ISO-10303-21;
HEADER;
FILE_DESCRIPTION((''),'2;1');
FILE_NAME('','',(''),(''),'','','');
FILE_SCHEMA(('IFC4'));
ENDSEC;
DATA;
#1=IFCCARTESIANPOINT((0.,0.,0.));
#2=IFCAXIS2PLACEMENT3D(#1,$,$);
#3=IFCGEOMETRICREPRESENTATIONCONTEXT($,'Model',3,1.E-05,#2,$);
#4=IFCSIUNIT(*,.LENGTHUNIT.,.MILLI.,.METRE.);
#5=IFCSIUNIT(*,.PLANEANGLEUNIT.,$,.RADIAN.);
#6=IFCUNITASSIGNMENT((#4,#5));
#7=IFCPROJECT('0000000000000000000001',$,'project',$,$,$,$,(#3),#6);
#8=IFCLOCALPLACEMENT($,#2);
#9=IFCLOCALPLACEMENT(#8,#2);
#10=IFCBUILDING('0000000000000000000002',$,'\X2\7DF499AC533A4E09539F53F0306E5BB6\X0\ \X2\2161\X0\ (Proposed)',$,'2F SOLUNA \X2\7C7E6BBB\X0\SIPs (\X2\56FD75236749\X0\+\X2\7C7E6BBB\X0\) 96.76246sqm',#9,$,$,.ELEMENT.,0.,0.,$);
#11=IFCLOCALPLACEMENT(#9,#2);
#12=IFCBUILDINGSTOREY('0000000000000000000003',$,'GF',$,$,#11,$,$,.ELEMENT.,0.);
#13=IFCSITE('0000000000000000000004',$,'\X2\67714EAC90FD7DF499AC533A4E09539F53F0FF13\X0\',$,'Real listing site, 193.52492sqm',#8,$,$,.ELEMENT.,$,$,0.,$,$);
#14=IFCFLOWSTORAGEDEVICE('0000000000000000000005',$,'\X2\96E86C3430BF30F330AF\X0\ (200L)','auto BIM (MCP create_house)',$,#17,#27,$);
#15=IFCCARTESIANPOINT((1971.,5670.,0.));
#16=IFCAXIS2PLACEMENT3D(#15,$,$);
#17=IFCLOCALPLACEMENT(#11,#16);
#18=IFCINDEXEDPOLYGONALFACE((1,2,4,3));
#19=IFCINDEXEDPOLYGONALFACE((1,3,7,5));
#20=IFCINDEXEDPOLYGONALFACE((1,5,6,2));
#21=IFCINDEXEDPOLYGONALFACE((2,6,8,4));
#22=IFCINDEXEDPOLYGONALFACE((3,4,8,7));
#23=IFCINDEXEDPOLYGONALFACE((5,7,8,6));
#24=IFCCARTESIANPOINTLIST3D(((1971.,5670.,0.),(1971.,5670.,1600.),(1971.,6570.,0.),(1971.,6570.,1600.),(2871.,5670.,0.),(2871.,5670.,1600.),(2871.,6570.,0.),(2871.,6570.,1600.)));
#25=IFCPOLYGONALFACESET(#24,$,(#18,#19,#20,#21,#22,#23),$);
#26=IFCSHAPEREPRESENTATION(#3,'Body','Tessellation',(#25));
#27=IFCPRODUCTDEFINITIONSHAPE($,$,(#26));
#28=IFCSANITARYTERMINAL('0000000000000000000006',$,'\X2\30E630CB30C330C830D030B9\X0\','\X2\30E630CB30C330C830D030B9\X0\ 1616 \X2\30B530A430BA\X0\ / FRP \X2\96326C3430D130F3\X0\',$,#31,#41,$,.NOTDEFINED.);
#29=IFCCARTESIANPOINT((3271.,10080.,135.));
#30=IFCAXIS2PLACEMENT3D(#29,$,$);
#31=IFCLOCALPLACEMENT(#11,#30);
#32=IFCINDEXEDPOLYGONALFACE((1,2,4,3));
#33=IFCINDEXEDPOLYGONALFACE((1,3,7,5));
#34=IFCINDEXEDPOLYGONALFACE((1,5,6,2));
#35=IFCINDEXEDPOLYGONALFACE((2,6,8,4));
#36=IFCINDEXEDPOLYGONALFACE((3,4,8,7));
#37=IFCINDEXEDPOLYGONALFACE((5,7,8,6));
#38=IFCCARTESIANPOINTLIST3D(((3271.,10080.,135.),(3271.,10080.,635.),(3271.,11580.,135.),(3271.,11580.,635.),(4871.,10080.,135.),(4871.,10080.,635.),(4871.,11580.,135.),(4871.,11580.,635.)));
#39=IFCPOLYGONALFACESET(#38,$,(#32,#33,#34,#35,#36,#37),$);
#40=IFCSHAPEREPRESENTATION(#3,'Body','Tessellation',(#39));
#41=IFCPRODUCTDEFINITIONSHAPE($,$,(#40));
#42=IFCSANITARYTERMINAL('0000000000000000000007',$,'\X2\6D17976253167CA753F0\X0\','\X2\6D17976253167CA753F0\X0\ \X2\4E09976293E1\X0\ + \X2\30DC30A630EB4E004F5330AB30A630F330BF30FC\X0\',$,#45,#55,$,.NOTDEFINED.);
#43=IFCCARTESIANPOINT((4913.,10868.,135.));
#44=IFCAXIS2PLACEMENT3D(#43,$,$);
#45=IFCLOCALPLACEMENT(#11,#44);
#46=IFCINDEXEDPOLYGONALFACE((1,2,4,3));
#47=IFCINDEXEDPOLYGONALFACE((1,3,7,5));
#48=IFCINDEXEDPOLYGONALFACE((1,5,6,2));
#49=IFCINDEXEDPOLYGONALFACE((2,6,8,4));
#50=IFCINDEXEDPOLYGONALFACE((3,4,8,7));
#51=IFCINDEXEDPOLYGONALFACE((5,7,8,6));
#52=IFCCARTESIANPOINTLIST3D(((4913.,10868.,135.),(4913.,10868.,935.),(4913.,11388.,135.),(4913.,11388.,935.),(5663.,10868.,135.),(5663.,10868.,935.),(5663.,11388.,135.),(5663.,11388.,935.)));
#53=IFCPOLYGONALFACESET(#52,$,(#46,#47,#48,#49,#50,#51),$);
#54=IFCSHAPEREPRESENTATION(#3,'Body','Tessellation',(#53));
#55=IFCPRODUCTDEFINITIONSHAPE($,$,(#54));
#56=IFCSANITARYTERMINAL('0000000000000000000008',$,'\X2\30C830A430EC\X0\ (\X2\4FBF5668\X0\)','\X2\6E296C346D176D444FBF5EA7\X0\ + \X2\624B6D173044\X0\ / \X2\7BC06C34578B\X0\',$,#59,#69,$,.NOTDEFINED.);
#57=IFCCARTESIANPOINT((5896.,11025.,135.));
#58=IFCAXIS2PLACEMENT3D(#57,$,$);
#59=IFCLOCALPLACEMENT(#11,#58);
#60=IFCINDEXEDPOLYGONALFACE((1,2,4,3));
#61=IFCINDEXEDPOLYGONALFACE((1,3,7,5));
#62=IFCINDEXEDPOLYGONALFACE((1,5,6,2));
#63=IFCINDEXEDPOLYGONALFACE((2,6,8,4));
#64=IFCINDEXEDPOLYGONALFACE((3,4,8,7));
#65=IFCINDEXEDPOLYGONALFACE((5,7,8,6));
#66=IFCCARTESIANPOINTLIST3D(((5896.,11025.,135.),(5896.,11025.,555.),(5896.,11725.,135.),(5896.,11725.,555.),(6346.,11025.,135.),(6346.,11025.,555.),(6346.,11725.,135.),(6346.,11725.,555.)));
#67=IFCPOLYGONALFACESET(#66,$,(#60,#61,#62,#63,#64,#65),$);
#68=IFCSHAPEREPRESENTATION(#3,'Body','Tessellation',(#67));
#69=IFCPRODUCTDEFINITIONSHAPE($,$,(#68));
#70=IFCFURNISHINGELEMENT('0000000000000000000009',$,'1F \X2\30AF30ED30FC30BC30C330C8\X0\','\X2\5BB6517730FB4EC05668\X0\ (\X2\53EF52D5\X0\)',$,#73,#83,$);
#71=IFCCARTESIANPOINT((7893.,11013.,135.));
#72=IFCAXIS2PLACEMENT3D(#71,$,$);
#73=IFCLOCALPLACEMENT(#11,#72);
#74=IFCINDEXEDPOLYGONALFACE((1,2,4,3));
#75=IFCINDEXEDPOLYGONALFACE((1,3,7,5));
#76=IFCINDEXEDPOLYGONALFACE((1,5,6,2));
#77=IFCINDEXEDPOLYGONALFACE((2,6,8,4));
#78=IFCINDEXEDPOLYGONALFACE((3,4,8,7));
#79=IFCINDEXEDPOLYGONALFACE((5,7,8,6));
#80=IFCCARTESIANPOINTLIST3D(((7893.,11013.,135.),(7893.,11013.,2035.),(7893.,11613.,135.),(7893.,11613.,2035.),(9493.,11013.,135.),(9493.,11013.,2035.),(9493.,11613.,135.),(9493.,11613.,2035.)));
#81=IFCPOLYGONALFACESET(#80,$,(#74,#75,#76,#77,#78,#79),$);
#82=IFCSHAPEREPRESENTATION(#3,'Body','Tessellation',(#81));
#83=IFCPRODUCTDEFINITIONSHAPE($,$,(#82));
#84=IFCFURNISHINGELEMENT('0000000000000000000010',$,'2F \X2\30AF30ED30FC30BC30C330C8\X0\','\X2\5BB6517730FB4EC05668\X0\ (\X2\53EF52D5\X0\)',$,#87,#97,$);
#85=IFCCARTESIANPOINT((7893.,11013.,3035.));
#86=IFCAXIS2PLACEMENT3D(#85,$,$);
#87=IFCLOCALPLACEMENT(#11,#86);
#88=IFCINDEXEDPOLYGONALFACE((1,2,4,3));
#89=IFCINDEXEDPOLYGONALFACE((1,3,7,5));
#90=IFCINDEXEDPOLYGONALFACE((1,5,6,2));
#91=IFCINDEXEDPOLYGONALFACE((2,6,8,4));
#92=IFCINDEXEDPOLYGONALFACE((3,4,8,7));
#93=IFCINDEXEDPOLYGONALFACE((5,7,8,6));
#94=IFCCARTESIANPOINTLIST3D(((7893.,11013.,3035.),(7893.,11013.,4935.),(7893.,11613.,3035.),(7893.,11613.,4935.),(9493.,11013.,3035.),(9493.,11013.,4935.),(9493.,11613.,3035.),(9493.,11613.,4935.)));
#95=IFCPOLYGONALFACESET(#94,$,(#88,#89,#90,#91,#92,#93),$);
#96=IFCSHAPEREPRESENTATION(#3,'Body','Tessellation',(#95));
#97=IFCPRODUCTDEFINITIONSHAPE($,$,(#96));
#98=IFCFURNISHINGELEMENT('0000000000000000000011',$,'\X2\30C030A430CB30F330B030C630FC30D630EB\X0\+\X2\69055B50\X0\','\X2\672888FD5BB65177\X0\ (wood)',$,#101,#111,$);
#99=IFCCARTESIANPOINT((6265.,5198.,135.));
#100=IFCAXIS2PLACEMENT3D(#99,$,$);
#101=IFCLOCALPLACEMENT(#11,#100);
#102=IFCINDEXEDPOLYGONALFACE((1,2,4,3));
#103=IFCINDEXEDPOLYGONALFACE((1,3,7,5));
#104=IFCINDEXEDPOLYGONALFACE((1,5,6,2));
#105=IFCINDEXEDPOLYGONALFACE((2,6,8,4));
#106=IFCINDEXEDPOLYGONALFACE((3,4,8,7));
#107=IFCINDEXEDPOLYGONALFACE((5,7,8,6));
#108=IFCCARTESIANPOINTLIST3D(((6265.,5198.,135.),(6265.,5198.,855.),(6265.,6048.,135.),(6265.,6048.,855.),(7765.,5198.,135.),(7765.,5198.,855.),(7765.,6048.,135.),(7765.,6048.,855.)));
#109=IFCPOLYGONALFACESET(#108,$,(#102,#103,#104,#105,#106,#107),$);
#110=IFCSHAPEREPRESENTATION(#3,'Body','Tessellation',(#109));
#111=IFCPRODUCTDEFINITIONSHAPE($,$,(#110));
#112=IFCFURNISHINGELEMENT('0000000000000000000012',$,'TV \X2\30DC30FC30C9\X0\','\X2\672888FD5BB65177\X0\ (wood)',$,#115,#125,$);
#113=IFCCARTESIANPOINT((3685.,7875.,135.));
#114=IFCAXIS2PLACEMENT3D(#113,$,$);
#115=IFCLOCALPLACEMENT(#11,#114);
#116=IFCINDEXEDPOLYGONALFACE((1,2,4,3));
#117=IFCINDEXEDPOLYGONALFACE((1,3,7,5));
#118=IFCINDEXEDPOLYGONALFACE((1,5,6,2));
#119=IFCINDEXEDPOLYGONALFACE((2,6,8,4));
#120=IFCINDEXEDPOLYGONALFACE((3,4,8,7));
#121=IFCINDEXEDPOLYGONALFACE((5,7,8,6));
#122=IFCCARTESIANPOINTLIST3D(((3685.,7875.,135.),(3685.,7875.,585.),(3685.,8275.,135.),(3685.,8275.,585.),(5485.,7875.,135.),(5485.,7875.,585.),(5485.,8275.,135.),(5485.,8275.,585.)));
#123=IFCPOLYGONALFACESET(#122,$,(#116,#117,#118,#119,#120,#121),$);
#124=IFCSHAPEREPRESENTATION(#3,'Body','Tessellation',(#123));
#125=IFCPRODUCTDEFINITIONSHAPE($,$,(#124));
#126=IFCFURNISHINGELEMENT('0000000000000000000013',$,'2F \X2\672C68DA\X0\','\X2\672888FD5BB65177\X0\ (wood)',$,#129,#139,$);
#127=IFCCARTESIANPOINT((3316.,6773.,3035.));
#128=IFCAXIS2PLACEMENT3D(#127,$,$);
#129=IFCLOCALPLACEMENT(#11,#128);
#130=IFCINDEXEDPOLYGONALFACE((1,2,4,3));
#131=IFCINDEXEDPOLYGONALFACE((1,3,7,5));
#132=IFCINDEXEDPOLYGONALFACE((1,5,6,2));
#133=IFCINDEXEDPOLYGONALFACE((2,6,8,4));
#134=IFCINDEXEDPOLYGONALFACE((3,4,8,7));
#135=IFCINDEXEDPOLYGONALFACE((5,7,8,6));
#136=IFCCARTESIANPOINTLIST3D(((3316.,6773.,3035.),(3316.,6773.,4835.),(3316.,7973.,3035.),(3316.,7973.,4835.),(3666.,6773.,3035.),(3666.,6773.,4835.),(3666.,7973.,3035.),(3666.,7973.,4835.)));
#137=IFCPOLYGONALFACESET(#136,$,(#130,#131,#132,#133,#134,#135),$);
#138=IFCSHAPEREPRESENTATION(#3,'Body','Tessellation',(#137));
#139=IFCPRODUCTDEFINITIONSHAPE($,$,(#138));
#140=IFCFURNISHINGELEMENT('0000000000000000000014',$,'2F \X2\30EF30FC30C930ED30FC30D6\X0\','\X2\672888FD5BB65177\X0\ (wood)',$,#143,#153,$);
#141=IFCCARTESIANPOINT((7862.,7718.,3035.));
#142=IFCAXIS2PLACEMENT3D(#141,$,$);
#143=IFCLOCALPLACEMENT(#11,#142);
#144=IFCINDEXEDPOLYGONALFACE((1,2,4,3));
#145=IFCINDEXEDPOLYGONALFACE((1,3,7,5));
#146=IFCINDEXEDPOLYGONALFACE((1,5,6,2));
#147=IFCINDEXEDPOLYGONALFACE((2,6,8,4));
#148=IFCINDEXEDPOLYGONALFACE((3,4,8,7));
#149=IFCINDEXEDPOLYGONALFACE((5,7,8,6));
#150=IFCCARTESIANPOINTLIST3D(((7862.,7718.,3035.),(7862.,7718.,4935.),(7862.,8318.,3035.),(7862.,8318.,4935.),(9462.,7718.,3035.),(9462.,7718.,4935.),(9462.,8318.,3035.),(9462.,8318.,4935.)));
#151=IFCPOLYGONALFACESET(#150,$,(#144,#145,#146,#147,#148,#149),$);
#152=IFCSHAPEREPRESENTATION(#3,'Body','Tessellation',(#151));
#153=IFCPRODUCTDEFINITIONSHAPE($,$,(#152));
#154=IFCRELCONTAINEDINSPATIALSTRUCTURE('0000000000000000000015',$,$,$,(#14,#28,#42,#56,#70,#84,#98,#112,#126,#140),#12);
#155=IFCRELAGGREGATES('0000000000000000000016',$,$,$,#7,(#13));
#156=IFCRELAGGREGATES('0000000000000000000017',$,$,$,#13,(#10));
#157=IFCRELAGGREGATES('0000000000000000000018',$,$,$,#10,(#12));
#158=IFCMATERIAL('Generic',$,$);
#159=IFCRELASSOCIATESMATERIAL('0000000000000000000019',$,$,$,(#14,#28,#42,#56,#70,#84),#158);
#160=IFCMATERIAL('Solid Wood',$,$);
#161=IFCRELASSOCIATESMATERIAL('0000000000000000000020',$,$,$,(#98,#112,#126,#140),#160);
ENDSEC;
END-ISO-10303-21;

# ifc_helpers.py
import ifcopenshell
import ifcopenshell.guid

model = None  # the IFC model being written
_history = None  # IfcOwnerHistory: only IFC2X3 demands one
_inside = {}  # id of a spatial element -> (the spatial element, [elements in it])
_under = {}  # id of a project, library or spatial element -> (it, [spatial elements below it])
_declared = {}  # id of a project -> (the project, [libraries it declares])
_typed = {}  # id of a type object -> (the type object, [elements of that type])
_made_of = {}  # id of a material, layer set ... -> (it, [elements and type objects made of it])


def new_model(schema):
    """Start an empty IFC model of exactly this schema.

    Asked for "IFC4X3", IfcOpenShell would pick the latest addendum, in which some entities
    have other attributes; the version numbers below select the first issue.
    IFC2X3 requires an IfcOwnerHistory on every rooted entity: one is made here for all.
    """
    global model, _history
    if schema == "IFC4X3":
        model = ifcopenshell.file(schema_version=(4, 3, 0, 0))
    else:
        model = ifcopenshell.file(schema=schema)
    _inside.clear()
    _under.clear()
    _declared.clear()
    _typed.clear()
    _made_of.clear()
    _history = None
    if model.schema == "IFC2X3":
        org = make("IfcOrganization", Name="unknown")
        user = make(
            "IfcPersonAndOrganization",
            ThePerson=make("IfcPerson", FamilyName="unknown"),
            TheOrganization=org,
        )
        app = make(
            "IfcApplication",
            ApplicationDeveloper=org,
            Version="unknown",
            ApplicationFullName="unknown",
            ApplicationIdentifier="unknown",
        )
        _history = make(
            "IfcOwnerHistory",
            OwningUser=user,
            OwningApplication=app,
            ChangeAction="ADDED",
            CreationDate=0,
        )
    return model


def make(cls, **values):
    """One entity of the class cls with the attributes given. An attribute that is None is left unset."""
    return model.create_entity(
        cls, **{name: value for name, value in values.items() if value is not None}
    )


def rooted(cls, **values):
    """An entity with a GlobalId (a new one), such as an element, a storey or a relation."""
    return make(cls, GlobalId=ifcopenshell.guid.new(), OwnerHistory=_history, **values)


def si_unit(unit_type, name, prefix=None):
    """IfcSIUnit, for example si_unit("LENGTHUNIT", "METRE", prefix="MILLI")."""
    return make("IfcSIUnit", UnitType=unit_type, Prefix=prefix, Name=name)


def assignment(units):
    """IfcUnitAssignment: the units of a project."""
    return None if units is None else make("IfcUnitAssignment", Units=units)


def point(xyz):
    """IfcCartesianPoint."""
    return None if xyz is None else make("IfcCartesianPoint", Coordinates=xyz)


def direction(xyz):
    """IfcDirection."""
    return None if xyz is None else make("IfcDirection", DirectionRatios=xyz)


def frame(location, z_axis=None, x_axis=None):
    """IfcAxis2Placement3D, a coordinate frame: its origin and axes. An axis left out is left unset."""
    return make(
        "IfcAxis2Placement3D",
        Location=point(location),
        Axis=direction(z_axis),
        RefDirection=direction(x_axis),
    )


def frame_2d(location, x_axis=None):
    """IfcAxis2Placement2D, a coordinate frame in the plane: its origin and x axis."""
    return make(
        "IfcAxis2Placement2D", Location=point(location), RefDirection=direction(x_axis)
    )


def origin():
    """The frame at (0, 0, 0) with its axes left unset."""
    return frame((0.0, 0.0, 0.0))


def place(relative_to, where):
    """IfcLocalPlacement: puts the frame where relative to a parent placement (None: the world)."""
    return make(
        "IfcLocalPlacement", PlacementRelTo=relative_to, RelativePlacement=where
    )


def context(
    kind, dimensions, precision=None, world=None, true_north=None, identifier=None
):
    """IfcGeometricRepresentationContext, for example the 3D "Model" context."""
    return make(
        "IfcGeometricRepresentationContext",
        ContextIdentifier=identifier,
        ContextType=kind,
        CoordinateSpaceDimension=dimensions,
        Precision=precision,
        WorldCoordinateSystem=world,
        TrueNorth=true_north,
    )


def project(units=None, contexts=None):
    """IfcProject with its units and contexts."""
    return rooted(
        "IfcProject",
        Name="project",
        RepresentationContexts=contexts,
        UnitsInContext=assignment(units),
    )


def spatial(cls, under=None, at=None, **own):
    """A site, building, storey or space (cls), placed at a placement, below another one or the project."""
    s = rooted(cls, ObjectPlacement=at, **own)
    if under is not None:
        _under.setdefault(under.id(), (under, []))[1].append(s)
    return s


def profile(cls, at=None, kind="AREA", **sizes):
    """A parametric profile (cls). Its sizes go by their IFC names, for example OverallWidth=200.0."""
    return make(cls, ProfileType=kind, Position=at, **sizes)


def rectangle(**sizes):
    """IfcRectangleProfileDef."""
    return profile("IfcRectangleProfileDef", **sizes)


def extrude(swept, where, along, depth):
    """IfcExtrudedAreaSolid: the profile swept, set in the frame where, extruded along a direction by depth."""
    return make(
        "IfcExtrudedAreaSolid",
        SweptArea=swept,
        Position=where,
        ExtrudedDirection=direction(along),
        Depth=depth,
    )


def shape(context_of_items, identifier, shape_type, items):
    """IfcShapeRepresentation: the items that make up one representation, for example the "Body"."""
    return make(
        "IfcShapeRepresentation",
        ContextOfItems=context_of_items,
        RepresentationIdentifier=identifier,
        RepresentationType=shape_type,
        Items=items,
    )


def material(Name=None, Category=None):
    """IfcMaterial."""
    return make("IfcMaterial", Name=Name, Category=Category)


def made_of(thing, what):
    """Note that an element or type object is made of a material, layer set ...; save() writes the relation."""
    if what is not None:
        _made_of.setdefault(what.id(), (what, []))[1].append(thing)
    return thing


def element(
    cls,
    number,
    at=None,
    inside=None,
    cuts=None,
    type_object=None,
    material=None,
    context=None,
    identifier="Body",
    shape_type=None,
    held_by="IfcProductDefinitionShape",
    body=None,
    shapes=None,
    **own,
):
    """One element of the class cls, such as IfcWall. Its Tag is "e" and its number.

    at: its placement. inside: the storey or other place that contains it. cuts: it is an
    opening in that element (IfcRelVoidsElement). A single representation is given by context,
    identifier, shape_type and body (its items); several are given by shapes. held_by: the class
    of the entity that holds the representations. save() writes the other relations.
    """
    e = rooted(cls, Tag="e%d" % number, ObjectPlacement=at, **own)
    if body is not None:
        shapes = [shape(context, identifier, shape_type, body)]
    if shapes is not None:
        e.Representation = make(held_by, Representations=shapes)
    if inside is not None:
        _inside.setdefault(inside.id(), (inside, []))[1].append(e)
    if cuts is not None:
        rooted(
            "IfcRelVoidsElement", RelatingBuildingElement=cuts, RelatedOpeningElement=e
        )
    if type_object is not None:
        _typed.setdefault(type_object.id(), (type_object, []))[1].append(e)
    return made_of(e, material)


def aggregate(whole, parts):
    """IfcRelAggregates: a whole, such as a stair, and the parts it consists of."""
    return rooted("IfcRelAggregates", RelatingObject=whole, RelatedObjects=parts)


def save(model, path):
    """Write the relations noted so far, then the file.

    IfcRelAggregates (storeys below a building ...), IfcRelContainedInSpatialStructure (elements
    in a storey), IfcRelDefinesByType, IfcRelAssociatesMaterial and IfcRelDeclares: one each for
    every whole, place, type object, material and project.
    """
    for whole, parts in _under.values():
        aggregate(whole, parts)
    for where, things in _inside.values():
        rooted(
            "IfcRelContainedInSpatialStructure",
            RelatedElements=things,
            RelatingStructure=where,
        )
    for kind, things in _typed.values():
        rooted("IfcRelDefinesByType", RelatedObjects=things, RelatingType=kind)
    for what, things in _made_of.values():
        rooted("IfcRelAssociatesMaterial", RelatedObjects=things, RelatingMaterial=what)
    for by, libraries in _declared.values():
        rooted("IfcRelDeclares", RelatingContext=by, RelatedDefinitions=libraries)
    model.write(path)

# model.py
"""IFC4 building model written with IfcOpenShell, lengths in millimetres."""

from ifc_helpers import new_model, si_unit, frame, frame_2d, origin, place, context, project, spatial, rectangle, extrude, material, element, save


model = new_model("IFC4")

# Units and contexts
model_context = context("Model", 3, precision=1e-05, world=origin())
ifc_project = project(units=[si_unit("LENGTHUNIT", "METRE", prefix="MILLI"), si_unit("PLANEANGLEUNIT", "RADIAN")], contexts=[model_context])

# Site, building, storey
site_placement = place(None, origin())
site = spatial("IfcSite", under=ifc_project, at=site_placement, Name="東京都練馬区三原台３", ObjectType="Real listing site, 193.52492sqm", CompositionType="ELEMENT", RefElevation=0.0)
building_placement = place(site_placement, origin())
building = spatial("IfcBuilding", under=site, at=building_placement, Name="練馬区三原台の家 Ⅱ (Proposed)", ObjectType="2F SOLUNA 籾殻SIPs (国産杉+籾殻) 96.76246sqm", CompositionType="ELEMENT", ElevationOfRefHeight=0.0, ElevationOfTerrain=0.0)
storey_placement = place(building_placement, origin())
storey = spatial("IfcBuildingStorey", under=building, at=storey_placement, Name="GF", CompositionType="ELEMENT", Elevation=0.0)

# Shared definitions
ifc_material_1 = material(Name="Solid Wood")

# Flow storage device
ifc_material_2 = material(Name="Generic")
flow_storage_device_placement = place(storey_placement, frame((1971.0, 5670.0, 0.0)))
element("IfcFlowStorageDevice", 1, at=flow_storage_device_placement, inside=storey, material=ifc_material_2, Name="雨水タンク (200L)", Description="auto BIM (MCP create_house)", context=model_context, shape_type="SweptSolid", body=[
    extrude(rectangle(XDim=900.0, YDim=900.0, at=frame_2d((450.0, 450.0))), frame((1971.0, 5670.0, 0.0)), (0.0, 0.0, 1.0), 1600.0),
])

# Sanitary terminals
sanitary_terminal_1_placement = place(storey_placement, frame((3271.0, 10080.0, 135.0)))
element("IfcSanitaryTerminal", 2, at=sanitary_terminal_1_placement, inside=storey, material=ifc_material_2, Name="ユニットバス", Description="ユニットバス 1616 サイズ / FRP 防水パン", PredefinedType="NOTDEFINED", context=model_context, shape_type="SweptSolid", body=[
    extrude(rectangle(XDim=1600.0, YDim=1500.0, at=frame_2d((800.0, 750.0))), frame((3271.0, 10080.0, 135.0)), (0.0, 0.0, 1.0), 500.0),
])
sanitary_terminal_2_placement = place(storey_placement, frame((4913.0, 10868.0, 135.0)))
element("IfcSanitaryTerminal", 3, at=sanitary_terminal_2_placement, inside=storey, material=ifc_material_2, Name="洗面化粧台", Description="洗面化粧台 三面鏡 + ボウル一体カウンター", PredefinedType="NOTDEFINED", context=model_context, shape_type="SweptSolid", body=[
    extrude(rectangle(XDim=750.0, YDim=520.0, at=frame_2d((375.0, 260.0))), frame((4913.0, 10868.0, 135.0)), (0.0, 0.0, 1.0), 800.0),
])
sanitary_terminal_3_placement = place(storey_placement, frame((5896.0, 11025.0, 135.0)))
element("IfcSanitaryTerminal", 4, at=sanitary_terminal_3_placement, inside=storey, material=ifc_material_2, Name="トイレ (便器)", Description="温水洗浄便座 + 手洗い / 節水型", PredefinedType="NOTDEFINED", context=model_context, shape_type="SweptSolid", body=[
    extrude(rectangle(XDim=450.0, YDim=700.0, at=frame_2d((225.0, 350.0))), frame((5896.0, 11025.0, 135.0)), (0.0, 0.0, 1.0), 420.0),
])

# Furnishing elements
furnishing_1_placement = place(storey_placement, frame((7893.0, 11013.0, 135.0)))
element("IfcFurnishingElement", 5, at=furnishing_1_placement, inside=storey, material=ifc_material_2, Name="1F クローゼット", Description="家具・什器 (可動)", context=model_context, shape_type="SweptSolid", body=[
    extrude(rectangle(XDim=1600.0, YDim=600.0, at=frame_2d((800.0, 300.0))), frame((7893.0, 11013.0, 135.0)), (0.0, 0.0, 1.0), 1900.0),
])
furnishing_2_placement = place(storey_placement, frame((7893.0, 11013.0, 3035.0)))
element("IfcFurnishingElement", 6, at=furnishing_2_placement, inside=storey, material=ifc_material_2, Name="2F クローゼット", Description="家具・什器 (可動)", context=model_context, shape_type="SweptSolid", body=[
    extrude(rectangle(XDim=1600.0, YDim=600.0, at=frame_2d((800.0, 300.0))), frame((7893.0, 11013.0, 3035.0)), (0.0, 0.0, 1.0), 1900.0),
])
furnishing_3_placement = place(storey_placement, frame((6265.0, 5198.0, 135.0)))
element("IfcFurnishingElement", 7, at=furnishing_3_placement, inside=storey, material=ifc_material_1, Name="ダイニングテーブル+椅子", Description="木製家具 (wood)", context=model_context, shape_type="SweptSolid", body=[
    extrude(rectangle(XDim=1500.0, YDim=850.0, at=frame_2d((750.0, 425.0))), frame((6265.0, 5198.0, 135.0)), (0.0, 0.0, 1.0), 720.0),
])
furnishing_4_placement = place(storey_placement, frame((3685.0, 7875.0, 135.0)))
element("IfcFurnishingElement", 8, at=furnishing_4_placement, inside=storey, material=ifc_material_1, Name="TV ボード", Description="木製家具 (wood)", context=model_context, shape_type="SweptSolid", body=[
    extrude(rectangle(XDim=1800.0, YDim=400.0, at=frame_2d((900.0, 200.0))), frame((3685.0, 7875.0, 135.0)), (0.0, 0.0, 1.0), 450.0),
])
furnishing_5_placement = place(storey_placement, frame((3316.0, 6773.0, 3035.0)))
element("IfcFurnishingElement", 9, at=furnishing_5_placement, inside=storey, material=ifc_material_1, Name="2F 本棚", Description="木製家具 (wood)", context=model_context, shape_type="SweptSolid", body=[
    extrude(rectangle(XDim=350.0, YDim=1200.0, at=frame_2d((175.0, 600.0))), frame((3316.0, 6773.0, 3035.0)), (0.0, 0.0, 1.0), 1800.0),
])
furnishing_6_placement = place(storey_placement, frame((7862.0, 7718.0, 3035.0)))
element("IfcFurnishingElement", 10, at=furnishing_6_placement, inside=storey, material=ifc_material_1, Name="2F ワードローブ", Description="木製家具 (wood)", context=model_context, shape_type="SweptSolid", body=[
    extrude(rectangle(XDim=1600.0, YDim=600.0, at=frame_2d((800.0, 300.0))), frame((7862.0, 7718.0, 3035.0)), (0.0, 0.0, 1.0), 1900.0),
])

save(model, "model.ifc")
